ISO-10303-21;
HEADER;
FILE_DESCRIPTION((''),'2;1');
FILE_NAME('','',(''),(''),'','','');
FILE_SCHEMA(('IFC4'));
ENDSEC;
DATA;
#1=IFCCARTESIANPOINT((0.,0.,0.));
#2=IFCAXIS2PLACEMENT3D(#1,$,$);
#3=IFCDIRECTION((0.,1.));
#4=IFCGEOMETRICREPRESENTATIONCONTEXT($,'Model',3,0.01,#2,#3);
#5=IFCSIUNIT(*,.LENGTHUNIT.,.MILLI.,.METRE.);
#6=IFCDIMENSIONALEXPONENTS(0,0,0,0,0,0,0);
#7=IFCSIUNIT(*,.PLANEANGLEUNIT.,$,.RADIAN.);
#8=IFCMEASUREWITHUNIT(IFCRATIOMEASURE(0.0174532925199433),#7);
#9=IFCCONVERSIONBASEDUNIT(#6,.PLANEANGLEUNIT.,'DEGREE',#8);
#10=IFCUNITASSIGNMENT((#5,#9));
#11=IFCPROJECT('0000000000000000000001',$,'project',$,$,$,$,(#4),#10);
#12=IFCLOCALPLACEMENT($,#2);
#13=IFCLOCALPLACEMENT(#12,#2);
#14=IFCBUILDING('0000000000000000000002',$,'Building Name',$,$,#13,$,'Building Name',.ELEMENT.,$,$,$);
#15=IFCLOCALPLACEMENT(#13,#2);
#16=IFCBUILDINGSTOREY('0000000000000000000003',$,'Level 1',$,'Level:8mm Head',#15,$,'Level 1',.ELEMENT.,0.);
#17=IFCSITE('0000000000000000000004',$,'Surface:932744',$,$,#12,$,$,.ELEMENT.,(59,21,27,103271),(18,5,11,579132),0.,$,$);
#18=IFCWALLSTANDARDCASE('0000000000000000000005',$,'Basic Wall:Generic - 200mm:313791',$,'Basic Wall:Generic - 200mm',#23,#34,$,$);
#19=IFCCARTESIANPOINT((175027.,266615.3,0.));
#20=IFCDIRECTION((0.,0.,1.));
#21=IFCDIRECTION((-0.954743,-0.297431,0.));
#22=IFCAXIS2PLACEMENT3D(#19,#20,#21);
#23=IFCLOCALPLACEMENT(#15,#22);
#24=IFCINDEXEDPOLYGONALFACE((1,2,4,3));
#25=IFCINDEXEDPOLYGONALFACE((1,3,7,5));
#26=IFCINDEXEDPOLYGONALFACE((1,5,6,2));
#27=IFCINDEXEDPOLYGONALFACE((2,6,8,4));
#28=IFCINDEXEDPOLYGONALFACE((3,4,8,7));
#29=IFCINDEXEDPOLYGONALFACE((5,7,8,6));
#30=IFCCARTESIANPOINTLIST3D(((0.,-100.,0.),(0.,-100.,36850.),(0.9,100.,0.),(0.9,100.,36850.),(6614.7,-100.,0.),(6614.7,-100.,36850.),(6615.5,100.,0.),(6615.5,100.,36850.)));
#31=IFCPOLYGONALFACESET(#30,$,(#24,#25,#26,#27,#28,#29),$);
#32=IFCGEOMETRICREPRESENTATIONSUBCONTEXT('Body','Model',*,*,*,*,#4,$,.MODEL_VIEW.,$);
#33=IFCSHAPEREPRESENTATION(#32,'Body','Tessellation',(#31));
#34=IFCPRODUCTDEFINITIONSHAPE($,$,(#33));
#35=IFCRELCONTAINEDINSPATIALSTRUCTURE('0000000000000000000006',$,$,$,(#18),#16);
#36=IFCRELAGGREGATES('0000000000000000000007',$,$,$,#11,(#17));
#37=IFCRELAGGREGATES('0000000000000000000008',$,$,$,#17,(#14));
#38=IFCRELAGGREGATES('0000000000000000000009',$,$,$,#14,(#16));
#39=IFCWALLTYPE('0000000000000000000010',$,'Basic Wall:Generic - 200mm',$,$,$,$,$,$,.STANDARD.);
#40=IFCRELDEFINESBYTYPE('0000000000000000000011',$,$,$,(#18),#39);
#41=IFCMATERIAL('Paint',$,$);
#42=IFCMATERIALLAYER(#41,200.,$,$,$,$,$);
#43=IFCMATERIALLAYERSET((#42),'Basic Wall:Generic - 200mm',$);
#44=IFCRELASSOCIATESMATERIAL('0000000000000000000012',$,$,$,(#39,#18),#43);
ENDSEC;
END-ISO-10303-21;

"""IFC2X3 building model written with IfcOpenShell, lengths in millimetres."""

from ifc_helpers import new_model, entity, si_unit, converted_unit, direction, frame, origin, place, context, subcontext, project, spatial, polyline, outline, extrude, clip, bounded_halfspace, material, layer, layer_set, layer_usage, type_object, element, save


model = new_model("IFC2X3")

# Units and contexts
model_context = context("Model", 3, precision=0.01, world=origin(), true_north=direction((0.0, 1.0)))
body_context = subcontext(model_context, "Body", "Model", "MODEL_VIEW")
ifc_project = project(units=[si_unit("LENGTHUNIT", "METRE", prefix="MILLI"), converted_unit("PLANEANGLEUNIT", "DEGREE", entity("IfcRatioMeasure", 0.0174532925199433), si_unit("PLANEANGLEUNIT", "RADIAN"), dimensions=[0, 0, 0, 0, 0, 0, 0])], contexts=[model_context])

# Site, building, storey
site_placement = place(None, origin())
site = spatial("IfcSite", under=ifc_project, at=site_placement, Name="Surface:932744", CompositionType="ELEMENT", RefLatitude=(59, 21, 27, 103271), RefLongitude=(18, 5, 11, 579132), RefElevation=0.0)
building_placement = place(site_placement, origin())
building = spatial("IfcBuilding", under=site, at=building_placement, Name="Building Name", LongName="Building Name", CompositionType="ELEMENT")
storey_placement = place(building_placement, origin())
storey = spatial("IfcBuildingStorey", under=building, at=storey_placement, Name="Level 1", ObjectType="Level:8mm Head", LongName="Level 1", CompositionType="ELEMENT", Elevation=0.0)

# Shared definitions
ifc_material_1 = material(Name="Paint")
ifc_layer_1 = layer(ifc_material_1, 200.0)
ifc_layer_set_1 = layer_set([ifc_layer_1], Name="Basic Wall:Generic - 200mm")
wall_type_1 = type_object("IfcWallType", Name="Basic Wall:Generic - 200mm", PredefinedType="STANDARD", material=ifc_layer_set_1)

# Wall
ifc_layer_usage_1 = layer_usage(ifc_layer_set_1, "AXIS2", "NEGATIVE", 100.0)
wall_1_placement = place(storey_placement, frame((175027.0, 266615.3, 0.0), z_axis=(0.0, 0.0, 1.0), x_axis=(-0.954743, -0.297431, 0.0)))
element("IfcWallStandardCase", 1, at=wall_1_placement, inside=storey, type_object=wall_type_1, material=ifc_layer_usage_1, Name="Basic Wall:Generic - 200mm:313791", ObjectType="Basic Wall:Generic - 200mm", context=body_context, shape_type="Clipping", body=[
    clip(extrude(outline(polyline([(6614.7, -100.0), (6615.5, 100.0), (6415.5, 100.0), (200.9, 100.0), (0.9, 100.0), (0.0, -100.0), (200.0, -100.0), (4528.4, -100.0), (4728.5, -100.0), (6614.7, -100.0)])), origin(), (0.0, 0.0, 1.0), 36850.0), bounded_halfspace(frame((0.0, -100.0, 36850.0), z_axis=(0.0, 0.0, -1.0), x_axis=(-0.003921, -0.999992, 0.0)), True, frame((0.0, -100.0, 36850.0), z_axis=(0.0, 0.0, -1.0), x_axis=(-0.003921, -0.999992, 0.0)), polyline([(0.0, 0.0), (-200.0, -0.2), (-200.8, -200.2), (-225.2, -6414.6), (-225.9, -6614.6), (-25.9, -6614.6), (0.0, 0.0)]))),
])

save(model, "model.ifc")
